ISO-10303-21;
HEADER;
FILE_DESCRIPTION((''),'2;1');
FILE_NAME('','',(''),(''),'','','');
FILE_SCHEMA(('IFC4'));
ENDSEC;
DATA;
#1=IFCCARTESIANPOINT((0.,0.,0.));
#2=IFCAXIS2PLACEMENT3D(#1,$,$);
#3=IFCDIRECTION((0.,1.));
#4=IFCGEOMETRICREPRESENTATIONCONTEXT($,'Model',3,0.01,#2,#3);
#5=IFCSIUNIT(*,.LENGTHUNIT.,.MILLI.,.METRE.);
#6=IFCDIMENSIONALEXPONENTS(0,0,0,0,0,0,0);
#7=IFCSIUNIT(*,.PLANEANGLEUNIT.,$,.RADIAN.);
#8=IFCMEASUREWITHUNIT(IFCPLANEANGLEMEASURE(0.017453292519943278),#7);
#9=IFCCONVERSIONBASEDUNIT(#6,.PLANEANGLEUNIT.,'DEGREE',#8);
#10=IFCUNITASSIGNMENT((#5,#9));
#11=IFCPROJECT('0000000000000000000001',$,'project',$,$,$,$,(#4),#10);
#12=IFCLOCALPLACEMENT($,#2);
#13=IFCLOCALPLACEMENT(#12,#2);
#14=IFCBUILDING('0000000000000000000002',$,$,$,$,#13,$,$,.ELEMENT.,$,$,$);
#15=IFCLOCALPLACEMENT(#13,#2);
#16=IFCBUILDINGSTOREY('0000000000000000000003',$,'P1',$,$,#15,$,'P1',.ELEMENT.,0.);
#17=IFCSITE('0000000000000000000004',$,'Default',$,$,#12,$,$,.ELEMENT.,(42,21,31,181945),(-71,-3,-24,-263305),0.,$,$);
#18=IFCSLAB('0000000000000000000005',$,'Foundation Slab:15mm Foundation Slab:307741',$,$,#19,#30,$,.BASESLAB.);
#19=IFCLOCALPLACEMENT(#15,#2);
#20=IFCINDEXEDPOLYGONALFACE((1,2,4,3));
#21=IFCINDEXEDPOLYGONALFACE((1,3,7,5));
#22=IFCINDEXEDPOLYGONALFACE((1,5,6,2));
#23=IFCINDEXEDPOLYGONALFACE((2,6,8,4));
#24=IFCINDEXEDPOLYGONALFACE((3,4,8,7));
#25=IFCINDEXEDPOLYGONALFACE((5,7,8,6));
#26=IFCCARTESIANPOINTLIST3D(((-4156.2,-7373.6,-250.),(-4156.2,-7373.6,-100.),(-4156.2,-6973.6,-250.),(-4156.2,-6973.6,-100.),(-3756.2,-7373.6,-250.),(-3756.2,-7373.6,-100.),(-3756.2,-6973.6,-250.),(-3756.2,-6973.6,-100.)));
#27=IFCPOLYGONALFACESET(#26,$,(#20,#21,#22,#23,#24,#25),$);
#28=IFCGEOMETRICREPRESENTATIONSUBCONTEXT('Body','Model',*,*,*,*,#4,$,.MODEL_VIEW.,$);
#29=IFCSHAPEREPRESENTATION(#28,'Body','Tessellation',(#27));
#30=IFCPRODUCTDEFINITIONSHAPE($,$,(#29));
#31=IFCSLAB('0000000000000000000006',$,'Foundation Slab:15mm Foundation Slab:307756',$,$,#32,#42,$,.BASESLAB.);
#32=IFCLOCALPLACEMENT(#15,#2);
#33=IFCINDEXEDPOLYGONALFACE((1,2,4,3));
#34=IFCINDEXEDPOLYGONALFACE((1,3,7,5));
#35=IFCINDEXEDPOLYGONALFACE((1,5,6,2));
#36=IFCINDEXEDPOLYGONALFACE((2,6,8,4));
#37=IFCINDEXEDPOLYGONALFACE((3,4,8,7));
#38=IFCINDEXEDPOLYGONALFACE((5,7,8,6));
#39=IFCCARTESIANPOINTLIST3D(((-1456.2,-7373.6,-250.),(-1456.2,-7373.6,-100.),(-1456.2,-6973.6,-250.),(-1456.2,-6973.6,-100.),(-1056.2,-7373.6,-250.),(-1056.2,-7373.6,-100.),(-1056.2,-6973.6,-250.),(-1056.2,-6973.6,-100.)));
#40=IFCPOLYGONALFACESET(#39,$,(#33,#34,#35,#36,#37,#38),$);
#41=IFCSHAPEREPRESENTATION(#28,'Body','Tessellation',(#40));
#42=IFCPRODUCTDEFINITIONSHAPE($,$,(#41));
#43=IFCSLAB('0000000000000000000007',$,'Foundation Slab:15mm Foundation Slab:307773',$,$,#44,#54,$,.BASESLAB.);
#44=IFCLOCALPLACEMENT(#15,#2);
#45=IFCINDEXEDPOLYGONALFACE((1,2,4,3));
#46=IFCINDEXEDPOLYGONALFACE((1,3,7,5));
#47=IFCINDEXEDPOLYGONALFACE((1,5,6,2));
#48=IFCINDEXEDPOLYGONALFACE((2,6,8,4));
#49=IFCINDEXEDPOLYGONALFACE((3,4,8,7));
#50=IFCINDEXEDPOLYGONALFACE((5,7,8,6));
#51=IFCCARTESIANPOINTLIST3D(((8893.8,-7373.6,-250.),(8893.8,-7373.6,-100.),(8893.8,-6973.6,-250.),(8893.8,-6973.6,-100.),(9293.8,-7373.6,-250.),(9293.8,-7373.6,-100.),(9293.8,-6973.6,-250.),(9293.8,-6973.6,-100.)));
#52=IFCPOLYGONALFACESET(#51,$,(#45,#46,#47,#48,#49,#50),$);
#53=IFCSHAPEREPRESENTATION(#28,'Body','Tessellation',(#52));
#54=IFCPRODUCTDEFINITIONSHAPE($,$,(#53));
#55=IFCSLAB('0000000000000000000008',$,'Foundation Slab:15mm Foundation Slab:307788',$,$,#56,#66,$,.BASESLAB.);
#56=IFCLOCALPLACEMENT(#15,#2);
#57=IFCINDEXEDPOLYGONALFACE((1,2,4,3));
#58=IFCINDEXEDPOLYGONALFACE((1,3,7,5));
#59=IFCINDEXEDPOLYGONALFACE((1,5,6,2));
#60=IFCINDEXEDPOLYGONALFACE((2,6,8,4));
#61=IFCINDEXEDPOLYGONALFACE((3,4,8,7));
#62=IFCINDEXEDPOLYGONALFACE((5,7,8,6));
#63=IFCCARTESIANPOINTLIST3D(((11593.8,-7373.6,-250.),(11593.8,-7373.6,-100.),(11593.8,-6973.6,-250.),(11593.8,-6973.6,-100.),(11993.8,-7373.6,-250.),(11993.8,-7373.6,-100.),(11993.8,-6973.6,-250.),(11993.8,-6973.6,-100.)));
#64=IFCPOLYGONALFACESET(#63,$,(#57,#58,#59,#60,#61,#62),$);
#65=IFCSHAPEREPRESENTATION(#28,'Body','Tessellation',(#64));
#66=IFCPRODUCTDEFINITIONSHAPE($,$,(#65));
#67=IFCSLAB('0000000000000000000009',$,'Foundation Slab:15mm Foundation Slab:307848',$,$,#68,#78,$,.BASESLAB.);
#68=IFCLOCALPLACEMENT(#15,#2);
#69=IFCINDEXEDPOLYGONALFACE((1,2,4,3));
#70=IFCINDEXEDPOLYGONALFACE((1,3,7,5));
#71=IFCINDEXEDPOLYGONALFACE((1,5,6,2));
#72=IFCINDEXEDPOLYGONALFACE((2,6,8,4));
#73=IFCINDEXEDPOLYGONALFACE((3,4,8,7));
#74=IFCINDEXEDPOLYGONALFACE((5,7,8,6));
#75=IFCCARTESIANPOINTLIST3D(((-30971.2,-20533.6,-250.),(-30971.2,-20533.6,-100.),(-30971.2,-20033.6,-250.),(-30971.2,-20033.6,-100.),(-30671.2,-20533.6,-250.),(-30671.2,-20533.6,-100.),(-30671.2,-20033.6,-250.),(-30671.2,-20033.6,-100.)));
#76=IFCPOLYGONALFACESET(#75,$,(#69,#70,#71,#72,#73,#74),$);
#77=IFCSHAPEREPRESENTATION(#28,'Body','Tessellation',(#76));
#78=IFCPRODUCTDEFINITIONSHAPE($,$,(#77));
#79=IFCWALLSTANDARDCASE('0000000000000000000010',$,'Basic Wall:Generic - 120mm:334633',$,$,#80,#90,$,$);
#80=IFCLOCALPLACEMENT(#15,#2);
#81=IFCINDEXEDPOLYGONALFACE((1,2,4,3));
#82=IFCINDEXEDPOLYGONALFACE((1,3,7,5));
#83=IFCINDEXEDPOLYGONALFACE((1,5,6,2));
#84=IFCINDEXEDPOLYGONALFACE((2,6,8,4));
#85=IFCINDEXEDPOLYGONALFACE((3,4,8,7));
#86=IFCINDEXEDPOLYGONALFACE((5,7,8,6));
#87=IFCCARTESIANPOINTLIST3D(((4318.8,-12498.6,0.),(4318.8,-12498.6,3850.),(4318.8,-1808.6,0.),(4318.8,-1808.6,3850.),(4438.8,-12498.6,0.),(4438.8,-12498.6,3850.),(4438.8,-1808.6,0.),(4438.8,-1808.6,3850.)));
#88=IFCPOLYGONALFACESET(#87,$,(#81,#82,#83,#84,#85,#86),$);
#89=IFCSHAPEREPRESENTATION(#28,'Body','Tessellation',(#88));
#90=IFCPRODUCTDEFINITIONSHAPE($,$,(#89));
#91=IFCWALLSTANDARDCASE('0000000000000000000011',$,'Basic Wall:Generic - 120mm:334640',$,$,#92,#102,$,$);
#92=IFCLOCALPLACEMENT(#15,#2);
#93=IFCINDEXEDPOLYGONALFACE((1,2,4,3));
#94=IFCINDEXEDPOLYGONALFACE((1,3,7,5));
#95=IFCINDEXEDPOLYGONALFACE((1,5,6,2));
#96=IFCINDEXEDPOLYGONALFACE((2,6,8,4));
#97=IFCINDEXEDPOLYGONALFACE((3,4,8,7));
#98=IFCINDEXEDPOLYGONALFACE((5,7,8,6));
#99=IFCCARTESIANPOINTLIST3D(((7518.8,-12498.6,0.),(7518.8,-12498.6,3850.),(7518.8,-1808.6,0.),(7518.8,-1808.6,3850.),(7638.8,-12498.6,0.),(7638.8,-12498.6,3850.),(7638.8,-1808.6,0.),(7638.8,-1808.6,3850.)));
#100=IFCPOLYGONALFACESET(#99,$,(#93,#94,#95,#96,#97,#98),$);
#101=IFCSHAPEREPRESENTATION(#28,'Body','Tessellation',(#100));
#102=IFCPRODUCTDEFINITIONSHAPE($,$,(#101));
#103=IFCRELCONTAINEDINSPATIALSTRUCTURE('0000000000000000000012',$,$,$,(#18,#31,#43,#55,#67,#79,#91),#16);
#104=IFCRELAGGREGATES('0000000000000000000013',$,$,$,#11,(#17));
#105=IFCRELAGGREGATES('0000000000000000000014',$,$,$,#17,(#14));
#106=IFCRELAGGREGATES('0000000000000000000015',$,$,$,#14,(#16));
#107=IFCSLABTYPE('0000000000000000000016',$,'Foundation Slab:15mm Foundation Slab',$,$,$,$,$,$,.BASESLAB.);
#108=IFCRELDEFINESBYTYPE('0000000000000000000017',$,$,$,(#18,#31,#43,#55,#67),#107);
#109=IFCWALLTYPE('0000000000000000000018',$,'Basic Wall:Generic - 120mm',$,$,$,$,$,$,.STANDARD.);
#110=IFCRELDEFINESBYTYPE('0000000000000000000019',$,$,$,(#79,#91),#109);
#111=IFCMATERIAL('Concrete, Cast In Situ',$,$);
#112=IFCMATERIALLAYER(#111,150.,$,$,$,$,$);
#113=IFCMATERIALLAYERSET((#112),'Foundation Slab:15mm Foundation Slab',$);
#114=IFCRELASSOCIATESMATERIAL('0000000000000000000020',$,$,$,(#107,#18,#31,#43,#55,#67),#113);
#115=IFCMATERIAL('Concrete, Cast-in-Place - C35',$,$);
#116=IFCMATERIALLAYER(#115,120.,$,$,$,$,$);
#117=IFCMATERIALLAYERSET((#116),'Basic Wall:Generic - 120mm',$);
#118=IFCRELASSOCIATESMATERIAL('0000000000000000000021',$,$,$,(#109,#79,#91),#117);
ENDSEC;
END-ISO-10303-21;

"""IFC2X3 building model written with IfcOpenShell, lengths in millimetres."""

from ifc_helpers import new_model, entity, si_unit, converted_unit, direction, frame, frame_2d, origin, origin_2d_with_axis, place, context, subcontext, project, spatial, rectangle, extrude, material, layer, layer_set, layer_usage, type_object, element, save


model = new_model("IFC2X3")

# Units and contexts
model_context = context("Model", 3, precision=0.01, world=origin(), true_north=direction((0.0, 1.0)))
body_context = subcontext(model_context, "Body", "Model", "MODEL_VIEW")
ifc_project = project(units=[si_unit("LENGTHUNIT", "METRE", prefix="MILLI"), converted_unit("PLANEANGLEUNIT", "DEGREE", entity("IfcPlaneAngleMeasure", 0.017453292519943278), si_unit("PLANEANGLEUNIT", "RADIAN"), dimensions=[0, 0, 0, 0, 0, 0, 0])], contexts=[model_context])

# Site, building, storey
site_placement = place(None, origin())
site = spatial("IfcSite", under=ifc_project, at=site_placement, Name="Default", CompositionType="ELEMENT", RefLatitude=(42, 21, 31, 181945), RefLongitude=(-71, -3, -24, -263305), RefElevation=0.0)
building_placement = place(site_placement, origin())
building = spatial("IfcBuilding", under=site, at=building_placement, CompositionType="ELEMENT")
storey_placement = place(building_placement, origin())
storey = spatial("IfcBuildingStorey", under=building, at=storey_placement, Name="P1", LongName="P1", CompositionType="ELEMENT", Elevation=0.0)

# Shared definitions
ifc_material_1 = material(Name="Concrete, Cast-in-Place - C35")

# Slabs
ifc_material_2 = material(Name="Concrete, Cast In Situ")
ifc_layer_1 = layer(ifc_material_2, 150.0)
ifc_layer_set_1 = layer_set([ifc_layer_1], Name="Foundation Slab:15mm Foundation Slab")
slab_type = type_object("IfcSlabType", Name="Foundation Slab:15mm Foundation Slab", PredefinedType="BASESLAB", material=ifc_layer_set_1)
ifc_layer_usage_1 = layer_usage(ifc_layer_set_1, "AXIS3", "POSITIVE", 0.0)
slab_1_placement = place(storey_placement, origin())
element("IfcSlab", 1, at=slab_1_placement, inside=storey, type_object=slab_type, material=ifc_layer_usage_1, Name="Foundation Slab:15mm Foundation Slab:307741", PredefinedType="BASESLAB", context=body_context, shape_type="SweptSolid", body=[
    extrude(rectangle(XDim=400.0, YDim=400.0, at=origin_2d_with_axis()), frame((-3956.2, -7173.6, -100.0), z_axis=(0.0, 0.0, -1.0), x_axis=(0.0, 1.0, 0.0)), (0.0, 0.0, 1.0), 150.0),
])
ifc_layer_usage_2 = layer_usage(ifc_layer_set_1, "AXIS3", "POSITIVE", 0.0)
slab_2_placement = place(storey_placement, origin())
element("IfcSlab", 2, at=slab_2_placement, inside=storey, type_object=slab_type, material=ifc_layer_usage_2, Name="Foundation Slab:15mm Foundation Slab:307756", PredefinedType="BASESLAB", context=body_context, shape_type="SweptSolid", body=[
    extrude(rectangle(XDim=400.0, YDim=400.0, at=origin_2d_with_axis()), frame((-1256.2, -7173.6, -100.0), z_axis=(0.0, 0.0, -1.0), x_axis=(0.0, 1.0, 0.0)), (0.0, 0.0, 1.0), 150.0),
])
ifc_layer_usage_3 = layer_usage(ifc_layer_set_1, "AXIS3", "POSITIVE", 0.0)
slab_3_placement = place(storey_placement, origin())
element("IfcSlab", 3, at=slab_3_placement, inside=storey, type_object=slab_type, material=ifc_layer_usage_3, Name="Foundation Slab:15mm Foundation Slab:307773", PredefinedType="BASESLAB", context=body_context, shape_type="SweptSolid", body=[
    extrude(rectangle(XDim=400.0, YDim=400.0, at=origin_2d_with_axis()), frame((9093.8, -7173.6, -100.0), z_axis=(0.0, 0.0, -1.0), x_axis=(0.0, 1.0, 0.0)), (0.0, 0.0, 1.0), 150.0),
])
ifc_layer_usage_4 = layer_usage(ifc_layer_set_1, "AXIS3", "POSITIVE", 0.0)
slab_4_placement = place(storey_placement, origin())
element("IfcSlab", 4, at=slab_4_placement, inside=storey, type_object=slab_type, material=ifc_layer_usage_4, Name="Foundation Slab:15mm Foundation Slab:307788", PredefinedType="BASESLAB", context=body_context, shape_type="SweptSolid", body=[
    extrude(rectangle(XDim=400.0, YDim=400.0, at=origin_2d_with_axis()), frame((11793.8, -7173.6, -100.0), z_axis=(0.0, 0.0, -1.0), x_axis=(0.0, 1.0, 0.0)), (0.0, 0.0, 1.0), 150.0),
])
ifc_layer_usage_5 = layer_usage(ifc_layer_set_1, "AXIS3", "POSITIVE", 0.0)
slab_5_placement = place(storey_placement, origin())
element("IfcSlab", 5, at=slab_5_placement, inside=storey, type_object=slab_type, material=ifc_layer_usage_5, Name="Foundation Slab:15mm Foundation Slab:307848", PredefinedType="BASESLAB", context=body_context, shape_type="SweptSolid", body=[
    extrude(rectangle(XDim=500.0, YDim=300.0, at=origin_2d_with_axis()), frame((-30821.2, -20283.6, -100.0), z_axis=(0.0, 0.0, -1.0), x_axis=(0.0, 1.0, 0.0)), (0.0, 0.0, 1.0), 150.0),
])

# Walls
ifc_layer_2 = layer(ifc_material_1, 120.0)
ifc_layer_set_2 = layer_set([ifc_layer_2], Name="Basic Wall:Generic - 120mm")
ifc_layer_usage_6 = layer_usage(ifc_layer_set_2, "AXIS2", "NEGATIVE", 60.0)
wall_type = type_object("IfcWallType", Name="Basic Wall:Generic - 120mm", PredefinedType="STANDARD", material=ifc_layer_set_2)
wall_1_placement = place(storey_placement, frame((4378.8, -1808.6, 0.0), z_axis=(0.0, 0.0, 1.0), x_axis=(0.0, -1.0, 0.0)))
element("IfcWallStandardCase", 6, at=wall_1_placement, inside=storey, type_object=wall_type, material=ifc_layer_usage_6, Name="Basic Wall:Generic - 120mm:334633", context=body_context, shape_type="SweptSolid", body=[
    extrude(rectangle(XDim=10690.0, YDim=120.0, at=frame_2d((5345.0, 0.0), x_axis=(-1.0, 0.0))), origin(), (0.0, 0.0, 1.0), 3850.0),
])
ifc_layer_usage_7 = layer_usage(ifc_layer_set_2, "AXIS2", "NEGATIVE", 60.0)
wall_2_placement = place(storey_placement, frame((7578.8, -1808.6, 0.0), z_axis=(0.0, 0.0, 1.0), x_axis=(0.0, -1.0, 0.0)))
element("IfcWallStandardCase", 7, at=wall_2_placement, inside=storey, type_object=wall_type, material=ifc_layer_usage_7, Name="Basic Wall:Generic - 120mm:334640", context=body_context, shape_type="SweptSolid", body=[
    extrude(rectangle(XDim=10690.0, YDim=120.0, at=frame_2d((5345.0, 0.0), x_axis=(-1.0, 0.0))), origin(), (0.0, 0.0, 1.0), 3850.0),
])

save(model, "model.ifc")
